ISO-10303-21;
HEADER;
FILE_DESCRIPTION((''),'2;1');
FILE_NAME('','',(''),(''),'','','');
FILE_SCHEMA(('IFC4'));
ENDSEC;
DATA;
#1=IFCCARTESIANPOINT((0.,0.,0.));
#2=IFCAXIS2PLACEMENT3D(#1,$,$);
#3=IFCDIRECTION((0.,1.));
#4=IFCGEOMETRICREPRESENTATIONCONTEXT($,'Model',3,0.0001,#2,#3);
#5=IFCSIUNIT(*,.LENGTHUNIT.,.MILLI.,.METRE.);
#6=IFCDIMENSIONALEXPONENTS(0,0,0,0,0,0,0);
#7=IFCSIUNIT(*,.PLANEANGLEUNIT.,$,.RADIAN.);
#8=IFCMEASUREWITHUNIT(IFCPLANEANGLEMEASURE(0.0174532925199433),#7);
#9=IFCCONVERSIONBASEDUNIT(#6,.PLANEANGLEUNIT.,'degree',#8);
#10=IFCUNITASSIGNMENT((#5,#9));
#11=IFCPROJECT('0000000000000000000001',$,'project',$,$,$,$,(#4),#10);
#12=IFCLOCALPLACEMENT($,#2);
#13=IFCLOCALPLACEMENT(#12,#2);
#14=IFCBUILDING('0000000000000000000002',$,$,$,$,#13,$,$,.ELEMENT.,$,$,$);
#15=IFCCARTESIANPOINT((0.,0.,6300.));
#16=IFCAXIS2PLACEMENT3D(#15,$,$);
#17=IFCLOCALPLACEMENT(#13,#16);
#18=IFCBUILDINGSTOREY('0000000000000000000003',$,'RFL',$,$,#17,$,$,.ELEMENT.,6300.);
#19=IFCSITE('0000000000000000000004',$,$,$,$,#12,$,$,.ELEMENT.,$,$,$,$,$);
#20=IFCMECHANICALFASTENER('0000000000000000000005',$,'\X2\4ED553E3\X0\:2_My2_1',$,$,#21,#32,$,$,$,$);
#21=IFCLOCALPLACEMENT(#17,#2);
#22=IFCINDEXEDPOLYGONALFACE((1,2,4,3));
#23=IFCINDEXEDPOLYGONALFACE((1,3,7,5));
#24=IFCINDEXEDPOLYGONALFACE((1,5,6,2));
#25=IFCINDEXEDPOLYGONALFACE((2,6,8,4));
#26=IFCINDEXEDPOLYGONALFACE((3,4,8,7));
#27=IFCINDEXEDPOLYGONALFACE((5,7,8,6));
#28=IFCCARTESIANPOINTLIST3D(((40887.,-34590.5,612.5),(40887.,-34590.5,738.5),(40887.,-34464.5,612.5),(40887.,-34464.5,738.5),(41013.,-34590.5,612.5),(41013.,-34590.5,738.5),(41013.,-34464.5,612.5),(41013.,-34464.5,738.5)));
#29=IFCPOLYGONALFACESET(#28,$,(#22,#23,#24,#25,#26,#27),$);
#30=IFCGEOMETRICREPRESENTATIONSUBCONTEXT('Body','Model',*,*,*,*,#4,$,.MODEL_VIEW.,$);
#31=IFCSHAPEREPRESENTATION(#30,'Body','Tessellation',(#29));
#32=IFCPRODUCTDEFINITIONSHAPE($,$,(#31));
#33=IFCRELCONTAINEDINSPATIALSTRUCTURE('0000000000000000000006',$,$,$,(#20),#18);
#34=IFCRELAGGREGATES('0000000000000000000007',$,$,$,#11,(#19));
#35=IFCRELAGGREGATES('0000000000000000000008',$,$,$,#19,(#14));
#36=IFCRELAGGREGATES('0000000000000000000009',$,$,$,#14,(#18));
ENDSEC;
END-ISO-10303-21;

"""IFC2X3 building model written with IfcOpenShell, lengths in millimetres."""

from ifc_helpers import new_model, entity, si_unit, converted_unit, direction, frame, origin, origin_with_axes, origin_2d, place, context, subcontext, project, spatial, rectangle, extrude, element, save


model = new_model("IFC2X3")

# Units and contexts
model_context = context("Model", 3, precision=0.0001, world=origin(), true_north=direction((0.0, 1.0)))
body_context = subcontext(model_context, "Body", "Model", "MODEL_VIEW")
ifc_project = project(units=[si_unit("LENGTHUNIT", "METRE", prefix="MILLI"), converted_unit("PLANEANGLEUNIT", "degree", entity("IfcPlaneAngleMeasure", 0.0174532925199433), si_unit("PLANEANGLEUNIT", "RADIAN"), dimensions=[0, 0, 0, 0, 0, 0, 0])], contexts=[model_context])

# Site, building, storey
site_placement = place(None, origin())
site = spatial("IfcSite", under=ifc_project, at=site_placement, CompositionType="ELEMENT")
building_placement = place(site_placement, origin())
building = spatial("IfcBuilding", under=site, at=building_placement, CompositionType="ELEMENT")
storey_placement = place(building_placement, frame((0.0, 0.0, 6300.0)))
storey = spatial("IfcBuildingStorey", under=building, at=storey_placement, Name="RFL", CompositionType="ELEMENT", Elevation=6300.0)

# Mechanical fastener
for number, where, name in (
    (1, (40950.0, -34527.5, 612.5), "仕口:2_My2_1"),
):
    element("IfcMechanicalFastener", number, at=place(storey_placement, frame(where)), inside=storey, Name=name, context=body_context, shape_type="SweptSolid", body=[
        extrude(rectangle(XDim=126.0, YDim=126.0, at=origin_2d()), origin_with_axes(), (0.0, 0.0, 1.0), 126.0),
    ])

save(model, "model.ifc")
